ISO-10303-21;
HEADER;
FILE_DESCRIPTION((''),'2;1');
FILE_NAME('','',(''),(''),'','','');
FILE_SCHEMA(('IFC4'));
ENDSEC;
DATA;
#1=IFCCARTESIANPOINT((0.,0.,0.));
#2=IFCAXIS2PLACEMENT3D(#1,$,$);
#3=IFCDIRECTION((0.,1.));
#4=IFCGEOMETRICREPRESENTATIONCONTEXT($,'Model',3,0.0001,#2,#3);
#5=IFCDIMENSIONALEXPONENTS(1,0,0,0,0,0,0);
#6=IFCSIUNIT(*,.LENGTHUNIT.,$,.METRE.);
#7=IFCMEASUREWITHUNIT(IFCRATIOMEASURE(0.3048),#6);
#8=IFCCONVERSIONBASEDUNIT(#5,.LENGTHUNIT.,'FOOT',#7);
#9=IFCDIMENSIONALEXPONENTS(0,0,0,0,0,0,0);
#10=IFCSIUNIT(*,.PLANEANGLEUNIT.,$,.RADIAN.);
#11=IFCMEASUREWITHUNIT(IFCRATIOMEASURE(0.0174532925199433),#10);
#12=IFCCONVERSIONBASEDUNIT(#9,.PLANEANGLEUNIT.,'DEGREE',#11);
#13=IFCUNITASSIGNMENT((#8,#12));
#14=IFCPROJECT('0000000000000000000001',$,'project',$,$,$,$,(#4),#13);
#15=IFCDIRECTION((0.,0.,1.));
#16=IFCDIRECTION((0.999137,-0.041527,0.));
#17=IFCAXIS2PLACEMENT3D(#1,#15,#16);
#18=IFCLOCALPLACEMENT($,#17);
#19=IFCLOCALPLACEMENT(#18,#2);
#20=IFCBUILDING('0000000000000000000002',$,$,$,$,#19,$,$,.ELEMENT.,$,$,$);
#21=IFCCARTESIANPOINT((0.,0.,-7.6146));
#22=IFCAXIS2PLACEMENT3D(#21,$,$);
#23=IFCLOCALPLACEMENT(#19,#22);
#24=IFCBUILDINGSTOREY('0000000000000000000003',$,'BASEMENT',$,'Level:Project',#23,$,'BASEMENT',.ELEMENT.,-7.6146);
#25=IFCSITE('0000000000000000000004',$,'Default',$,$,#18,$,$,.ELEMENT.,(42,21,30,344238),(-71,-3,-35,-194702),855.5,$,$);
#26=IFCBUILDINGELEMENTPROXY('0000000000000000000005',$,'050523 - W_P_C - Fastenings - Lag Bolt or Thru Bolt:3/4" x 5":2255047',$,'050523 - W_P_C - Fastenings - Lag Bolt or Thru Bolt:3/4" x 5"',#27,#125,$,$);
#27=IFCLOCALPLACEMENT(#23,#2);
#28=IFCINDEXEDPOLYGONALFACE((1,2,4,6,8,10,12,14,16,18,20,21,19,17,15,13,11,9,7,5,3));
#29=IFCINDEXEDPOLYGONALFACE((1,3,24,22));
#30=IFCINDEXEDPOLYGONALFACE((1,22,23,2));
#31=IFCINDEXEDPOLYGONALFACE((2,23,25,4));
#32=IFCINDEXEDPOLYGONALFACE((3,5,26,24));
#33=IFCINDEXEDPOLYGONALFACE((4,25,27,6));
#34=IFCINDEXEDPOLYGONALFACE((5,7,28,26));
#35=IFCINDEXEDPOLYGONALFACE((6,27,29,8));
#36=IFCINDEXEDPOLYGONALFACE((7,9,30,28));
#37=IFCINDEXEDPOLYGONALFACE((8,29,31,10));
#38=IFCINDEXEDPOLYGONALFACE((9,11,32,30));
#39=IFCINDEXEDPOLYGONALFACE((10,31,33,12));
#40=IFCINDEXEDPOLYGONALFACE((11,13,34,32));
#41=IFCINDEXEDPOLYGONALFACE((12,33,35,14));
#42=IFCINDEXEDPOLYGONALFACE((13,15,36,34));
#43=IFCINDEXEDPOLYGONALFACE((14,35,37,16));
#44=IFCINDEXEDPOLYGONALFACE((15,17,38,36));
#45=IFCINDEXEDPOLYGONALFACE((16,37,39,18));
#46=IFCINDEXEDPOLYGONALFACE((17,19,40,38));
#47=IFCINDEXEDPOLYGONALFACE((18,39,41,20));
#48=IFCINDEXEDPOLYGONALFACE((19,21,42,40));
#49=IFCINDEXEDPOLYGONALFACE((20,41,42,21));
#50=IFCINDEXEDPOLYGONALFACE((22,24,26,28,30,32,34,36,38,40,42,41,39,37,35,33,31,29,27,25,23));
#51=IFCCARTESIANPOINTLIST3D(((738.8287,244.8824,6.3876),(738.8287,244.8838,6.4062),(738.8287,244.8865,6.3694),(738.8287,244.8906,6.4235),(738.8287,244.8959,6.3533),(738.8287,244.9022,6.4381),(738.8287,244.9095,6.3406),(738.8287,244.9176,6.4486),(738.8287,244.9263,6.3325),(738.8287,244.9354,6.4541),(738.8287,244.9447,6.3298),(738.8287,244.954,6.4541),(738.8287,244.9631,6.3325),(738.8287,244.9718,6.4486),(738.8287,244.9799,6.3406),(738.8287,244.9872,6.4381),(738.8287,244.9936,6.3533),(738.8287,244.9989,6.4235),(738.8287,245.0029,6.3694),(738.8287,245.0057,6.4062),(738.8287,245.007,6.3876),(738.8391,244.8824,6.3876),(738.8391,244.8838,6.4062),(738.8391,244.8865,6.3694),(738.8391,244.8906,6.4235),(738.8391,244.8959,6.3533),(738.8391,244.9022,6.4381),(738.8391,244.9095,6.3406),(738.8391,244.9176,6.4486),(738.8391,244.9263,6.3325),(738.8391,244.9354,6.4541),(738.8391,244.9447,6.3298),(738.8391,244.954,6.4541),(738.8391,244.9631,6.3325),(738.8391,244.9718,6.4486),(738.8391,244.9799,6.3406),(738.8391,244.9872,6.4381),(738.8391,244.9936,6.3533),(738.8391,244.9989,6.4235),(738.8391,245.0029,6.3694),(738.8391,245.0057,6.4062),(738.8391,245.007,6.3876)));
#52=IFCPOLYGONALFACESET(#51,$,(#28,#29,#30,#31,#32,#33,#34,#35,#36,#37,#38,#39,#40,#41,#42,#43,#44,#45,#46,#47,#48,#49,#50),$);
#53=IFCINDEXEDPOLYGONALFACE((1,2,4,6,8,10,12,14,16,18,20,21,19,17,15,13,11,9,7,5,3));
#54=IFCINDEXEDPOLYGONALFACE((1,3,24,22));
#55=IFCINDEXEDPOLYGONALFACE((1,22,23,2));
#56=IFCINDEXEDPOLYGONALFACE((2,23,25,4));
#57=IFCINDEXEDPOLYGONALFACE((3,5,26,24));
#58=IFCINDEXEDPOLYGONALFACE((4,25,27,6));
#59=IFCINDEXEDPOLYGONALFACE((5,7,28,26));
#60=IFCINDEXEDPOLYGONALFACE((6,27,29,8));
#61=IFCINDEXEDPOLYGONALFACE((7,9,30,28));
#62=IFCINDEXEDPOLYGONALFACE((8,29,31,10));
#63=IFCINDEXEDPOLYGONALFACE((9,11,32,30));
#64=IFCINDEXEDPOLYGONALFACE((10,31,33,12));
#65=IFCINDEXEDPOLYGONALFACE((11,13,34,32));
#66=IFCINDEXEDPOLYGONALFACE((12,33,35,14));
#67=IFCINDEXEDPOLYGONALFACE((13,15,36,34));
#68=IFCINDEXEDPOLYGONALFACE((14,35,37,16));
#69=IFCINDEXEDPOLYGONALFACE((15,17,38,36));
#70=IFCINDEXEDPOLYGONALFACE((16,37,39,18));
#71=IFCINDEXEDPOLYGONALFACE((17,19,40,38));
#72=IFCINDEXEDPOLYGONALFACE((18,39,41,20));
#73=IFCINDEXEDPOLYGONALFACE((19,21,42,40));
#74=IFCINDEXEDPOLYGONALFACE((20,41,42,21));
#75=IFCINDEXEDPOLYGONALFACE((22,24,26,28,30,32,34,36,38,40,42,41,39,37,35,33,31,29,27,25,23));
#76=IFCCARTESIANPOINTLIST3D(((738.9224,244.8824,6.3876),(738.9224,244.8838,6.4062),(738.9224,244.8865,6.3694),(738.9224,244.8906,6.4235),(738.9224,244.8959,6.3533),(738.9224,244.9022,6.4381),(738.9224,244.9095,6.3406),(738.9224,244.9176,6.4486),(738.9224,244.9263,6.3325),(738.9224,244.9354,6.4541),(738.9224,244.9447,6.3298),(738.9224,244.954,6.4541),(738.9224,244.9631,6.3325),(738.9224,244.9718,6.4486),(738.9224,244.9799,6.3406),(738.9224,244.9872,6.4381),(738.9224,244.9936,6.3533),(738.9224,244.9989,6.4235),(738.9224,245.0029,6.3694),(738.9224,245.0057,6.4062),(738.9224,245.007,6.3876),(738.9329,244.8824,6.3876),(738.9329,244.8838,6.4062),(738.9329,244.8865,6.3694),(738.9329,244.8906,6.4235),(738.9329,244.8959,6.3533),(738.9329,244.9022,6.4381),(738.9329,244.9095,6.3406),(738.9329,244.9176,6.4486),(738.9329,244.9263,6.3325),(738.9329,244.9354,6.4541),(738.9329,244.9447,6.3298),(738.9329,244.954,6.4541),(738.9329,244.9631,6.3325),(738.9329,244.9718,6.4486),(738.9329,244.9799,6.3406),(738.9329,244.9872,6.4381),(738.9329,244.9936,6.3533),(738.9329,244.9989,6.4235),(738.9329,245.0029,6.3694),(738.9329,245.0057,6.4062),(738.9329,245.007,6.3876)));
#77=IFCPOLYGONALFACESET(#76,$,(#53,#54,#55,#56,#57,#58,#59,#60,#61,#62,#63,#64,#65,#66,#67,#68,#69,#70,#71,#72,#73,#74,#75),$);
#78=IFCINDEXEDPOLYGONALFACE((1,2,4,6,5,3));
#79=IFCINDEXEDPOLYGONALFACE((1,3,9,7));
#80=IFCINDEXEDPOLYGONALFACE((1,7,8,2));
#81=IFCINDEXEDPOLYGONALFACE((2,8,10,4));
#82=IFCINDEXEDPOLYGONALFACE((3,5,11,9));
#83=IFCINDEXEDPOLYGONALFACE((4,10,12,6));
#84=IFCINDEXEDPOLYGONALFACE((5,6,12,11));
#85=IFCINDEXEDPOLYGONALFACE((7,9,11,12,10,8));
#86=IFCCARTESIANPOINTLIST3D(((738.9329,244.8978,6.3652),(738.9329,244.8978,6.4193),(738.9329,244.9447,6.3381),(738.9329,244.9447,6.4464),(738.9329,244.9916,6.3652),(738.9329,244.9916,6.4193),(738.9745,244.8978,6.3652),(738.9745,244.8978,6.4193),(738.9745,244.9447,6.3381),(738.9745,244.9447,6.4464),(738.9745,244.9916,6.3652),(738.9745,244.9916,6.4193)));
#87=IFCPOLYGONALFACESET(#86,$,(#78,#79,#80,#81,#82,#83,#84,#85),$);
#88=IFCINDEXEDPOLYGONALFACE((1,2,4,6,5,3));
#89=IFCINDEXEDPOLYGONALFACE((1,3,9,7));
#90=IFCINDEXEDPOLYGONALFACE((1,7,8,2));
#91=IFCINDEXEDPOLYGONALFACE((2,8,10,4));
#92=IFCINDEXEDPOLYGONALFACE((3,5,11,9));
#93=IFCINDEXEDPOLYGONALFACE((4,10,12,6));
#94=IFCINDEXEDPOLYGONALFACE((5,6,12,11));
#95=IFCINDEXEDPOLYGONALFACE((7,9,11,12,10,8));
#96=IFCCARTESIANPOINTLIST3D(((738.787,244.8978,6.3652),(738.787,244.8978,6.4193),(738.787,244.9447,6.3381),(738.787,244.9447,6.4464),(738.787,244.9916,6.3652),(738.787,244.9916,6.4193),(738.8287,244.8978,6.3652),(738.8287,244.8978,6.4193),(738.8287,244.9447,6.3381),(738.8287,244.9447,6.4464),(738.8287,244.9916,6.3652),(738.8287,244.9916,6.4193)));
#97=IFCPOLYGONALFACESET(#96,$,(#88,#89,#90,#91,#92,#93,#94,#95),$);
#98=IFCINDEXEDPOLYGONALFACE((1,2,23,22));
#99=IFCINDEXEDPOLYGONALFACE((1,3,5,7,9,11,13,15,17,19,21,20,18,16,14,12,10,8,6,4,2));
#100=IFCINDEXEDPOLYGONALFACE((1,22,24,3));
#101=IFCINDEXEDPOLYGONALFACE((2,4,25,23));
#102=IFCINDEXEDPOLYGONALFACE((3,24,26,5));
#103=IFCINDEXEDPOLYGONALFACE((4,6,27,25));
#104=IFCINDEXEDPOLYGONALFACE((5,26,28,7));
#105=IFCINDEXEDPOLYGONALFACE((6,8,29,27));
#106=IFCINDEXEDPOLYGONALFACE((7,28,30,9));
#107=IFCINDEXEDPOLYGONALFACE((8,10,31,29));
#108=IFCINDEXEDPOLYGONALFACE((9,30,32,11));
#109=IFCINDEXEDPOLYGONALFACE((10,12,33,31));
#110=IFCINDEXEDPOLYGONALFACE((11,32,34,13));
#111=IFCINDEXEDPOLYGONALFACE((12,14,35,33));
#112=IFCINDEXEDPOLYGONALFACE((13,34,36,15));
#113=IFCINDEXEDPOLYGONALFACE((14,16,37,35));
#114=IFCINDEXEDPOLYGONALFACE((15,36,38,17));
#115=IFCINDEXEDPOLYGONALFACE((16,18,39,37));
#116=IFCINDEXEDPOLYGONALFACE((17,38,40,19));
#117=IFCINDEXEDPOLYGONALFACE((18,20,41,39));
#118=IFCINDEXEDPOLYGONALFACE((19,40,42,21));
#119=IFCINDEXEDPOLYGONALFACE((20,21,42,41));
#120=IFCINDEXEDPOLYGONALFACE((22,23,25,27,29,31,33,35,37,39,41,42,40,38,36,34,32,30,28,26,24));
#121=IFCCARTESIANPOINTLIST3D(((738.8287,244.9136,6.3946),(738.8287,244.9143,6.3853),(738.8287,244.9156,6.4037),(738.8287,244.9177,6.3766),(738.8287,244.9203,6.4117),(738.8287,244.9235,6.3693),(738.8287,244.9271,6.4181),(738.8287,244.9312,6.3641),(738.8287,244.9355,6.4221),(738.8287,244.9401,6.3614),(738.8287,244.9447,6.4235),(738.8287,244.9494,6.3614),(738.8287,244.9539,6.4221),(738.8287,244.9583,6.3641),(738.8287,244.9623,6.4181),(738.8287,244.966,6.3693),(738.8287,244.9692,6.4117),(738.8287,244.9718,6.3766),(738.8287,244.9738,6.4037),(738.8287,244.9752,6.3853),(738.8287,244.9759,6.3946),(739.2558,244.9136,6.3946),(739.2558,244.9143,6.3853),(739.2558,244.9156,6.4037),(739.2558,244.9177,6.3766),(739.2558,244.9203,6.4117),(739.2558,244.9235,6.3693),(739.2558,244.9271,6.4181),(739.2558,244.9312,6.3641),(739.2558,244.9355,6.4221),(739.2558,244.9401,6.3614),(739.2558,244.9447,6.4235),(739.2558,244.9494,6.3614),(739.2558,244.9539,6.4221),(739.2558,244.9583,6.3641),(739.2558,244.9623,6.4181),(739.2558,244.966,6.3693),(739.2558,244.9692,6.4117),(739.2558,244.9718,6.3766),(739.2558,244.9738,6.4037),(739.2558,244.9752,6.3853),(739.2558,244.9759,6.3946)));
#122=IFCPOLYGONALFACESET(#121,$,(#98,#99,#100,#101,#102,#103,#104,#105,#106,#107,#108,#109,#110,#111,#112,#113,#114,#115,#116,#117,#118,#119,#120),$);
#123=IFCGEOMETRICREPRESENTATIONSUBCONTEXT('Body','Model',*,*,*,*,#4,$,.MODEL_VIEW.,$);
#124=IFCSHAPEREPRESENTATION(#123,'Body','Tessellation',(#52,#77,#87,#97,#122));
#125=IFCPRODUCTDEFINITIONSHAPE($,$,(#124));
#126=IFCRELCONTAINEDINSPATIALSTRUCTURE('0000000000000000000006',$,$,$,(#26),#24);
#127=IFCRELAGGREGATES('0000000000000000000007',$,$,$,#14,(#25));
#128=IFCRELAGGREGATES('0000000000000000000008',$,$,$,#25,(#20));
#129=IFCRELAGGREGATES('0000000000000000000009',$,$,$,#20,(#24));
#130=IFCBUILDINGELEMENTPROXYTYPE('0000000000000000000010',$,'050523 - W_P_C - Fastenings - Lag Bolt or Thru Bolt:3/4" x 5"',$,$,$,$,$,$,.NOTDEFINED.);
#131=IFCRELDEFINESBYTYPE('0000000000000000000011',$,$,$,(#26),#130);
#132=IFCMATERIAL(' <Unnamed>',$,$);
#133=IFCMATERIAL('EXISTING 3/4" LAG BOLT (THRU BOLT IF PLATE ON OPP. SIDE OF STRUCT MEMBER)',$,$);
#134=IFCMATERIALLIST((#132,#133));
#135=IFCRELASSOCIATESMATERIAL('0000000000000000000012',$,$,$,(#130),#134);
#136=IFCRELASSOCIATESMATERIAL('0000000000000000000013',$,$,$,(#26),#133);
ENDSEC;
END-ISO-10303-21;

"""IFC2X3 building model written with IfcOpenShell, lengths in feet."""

from ifc_helpers import new_model, entity, si_unit, converted_unit, direction, frame, frame_2d, origin, place, context, subcontext, project, spatial, polyline, circle, outline, extrude, source, transform, mapped, material, material_list, type_object, type_shapes, element, save


model = new_model("IFC2X3")

# Units and contexts
model_context = context("Model", 3, precision=0.0001, world=origin(), true_north=direction((0.0, 1.0)))
body_context = subcontext(model_context, "Body", "Model", "MODEL_VIEW")
ifc_project = project(units=[converted_unit("LENGTHUNIT", "FOOT", entity("IfcRatioMeasure", 0.3048), si_unit("LENGTHUNIT", "METRE"), dimensions=[1, 0, 0, 0, 0, 0, 0]), converted_unit("PLANEANGLEUNIT", "DEGREE", entity("IfcRatioMeasure", 0.0174532925199433), si_unit("PLANEANGLEUNIT", "RADIAN"), dimensions=[0, 0, 0, 0, 0, 0, 0])], contexts=[model_context])

# Site, building, storey
site_placement = place(None, frame((0.0, 0.0, 0.0), z_axis=(0.0, 0.0, 1.0), x_axis=(0.999137, -0.041527, 0.0)))
site = spatial("IfcSite", under=ifc_project, at=site_placement, Name="Default", CompositionType="ELEMENT", RefLatitude=(42, 21, 30, 344238), RefLongitude=(-71, -3, -35, -194702), RefElevation=855.5)
building_placement = place(site_placement, origin())
building = spatial("IfcBuilding", under=site, at=building_placement, CompositionType="ELEMENT")
storey_placement = place(building_placement, frame((0.0, 0.0, -7.6146)))
storey = spatial("IfcBuildingStorey", under=building, at=storey_placement, Name="BASEMENT", ObjectType="Level:Project", LongName="BASEMENT", CompositionType="ELEMENT", Elevation=-7.6146)

# Building element proxy
ifc_material_1 = material(Name="EXISTING 3/4\" LAG BOLT (THRU BOLT IF PLATE ON OPP. SIDE OF STRUCT MEMBER)")
ifc_material_2 = material(Name=" <Unnamed>")
ifc_material_list_1 = material_list([ifc_material_2, ifc_material_1])
building_element_proxy_type_1 = type_object("IfcBuildingElementProxyType", Name="050523 - W_P_C - Fastenings - Lag Bolt or Thru Bolt:3/4\" x 5\"", PredefinedType="NOTDEFINED", material=ifc_material_list_1)
shared_shape_1 = source(origin(), body_context, "Body", "SweptSolid", [
    extrude(circle(Radius=0.0625, at=frame_2d((0.0, 0.0), x_axis=(1.0, 0.0))), frame((0.0, 0.0, 0.0), z_axis=(0.0, 0.0, 1.0), x_axis=(0.0, -1.0, 0.0)), (0.0, 0.0, 1.0), 0.0104),
    extrude(circle(Radius=0.0625, at=frame_2d((0.0, 0.0), x_axis=(1.0, 0.0))), frame((0.0, 0.0, -0.0938), z_axis=(0.0, 0.0, 1.0), x_axis=(0.0, -1.0, 0.0)), (0.0, 0.0, 1.0), 0.0104),
    extrude(outline(polyline([(-0.0271, -0.0469), (0.0271, -0.0469), (0.0541, 0.0), (0.0271, 0.0469), (-0.0271, 0.0469), (-0.0541, 0.0), (-0.0271, -0.0469)])), frame((0.0, 0.0, -0.1354), z_axis=(0.0, 0.0, 1.0), x_axis=(0.866025, -0.5, 0.0)), (0.0, 0.0, 1.0), 0.0417),
    extrude(outline(polyline([(-0.0271, -0.0469), (0.0271, -0.0469), (0.0541, 0.0), (0.0271, 0.0469), (-0.0271, 0.0469), (-0.0541, 0.0), (-0.0271, -0.0469)])), frame((0.0, 0.0, 0.0104), z_axis=(0.0, 0.0, 1.0), x_axis=(0.0, -1.0, 0.0)), (0.0, 0.0, 1.0), 0.0417),
    extrude(circle(Radius=0.0312, at=frame_2d((0.0, 0.0), x_axis=(1.0, 0.0))), frame((0.0, 0.0, -0.4167), z_axis=(0.0, 0.0, 1.0), x_axis=(0.0, 1.0, 0.0)), (0.0, 0.0, 1.0), 0.4271),
])
type_shapes(building_element_proxy_type_1, [shared_shape_1])
for number, where, z_axis, x_axis, name in (
    (1, (738.8391, 244.9447, 6.3923), (-1.0, 0.0, 0.0), (0.0, -1.0, 0.0), "050523 - W_P_C - Fastenings - Lag Bolt or Thru Bolt:3/4\" x 5\":2255047"),
):
    element("IfcBuildingElementProxy", number, at=place(storey_placement, frame(where, z_axis=z_axis, x_axis=x_axis)), inside=storey, type_object=building_element_proxy_type_1, material=ifc_material_1, Name=name, ObjectType="050523 - W_P_C - Fastenings - Lag Bolt or Thru Bolt:3/4\" x 5\"", context=body_context, shape_type="MappedRepresentation", body=[
        mapped(shared_shape_1, transform((0.0, 0.0, 0.0), scale=1.0)),
    ])

save(model, "model.ifc")
